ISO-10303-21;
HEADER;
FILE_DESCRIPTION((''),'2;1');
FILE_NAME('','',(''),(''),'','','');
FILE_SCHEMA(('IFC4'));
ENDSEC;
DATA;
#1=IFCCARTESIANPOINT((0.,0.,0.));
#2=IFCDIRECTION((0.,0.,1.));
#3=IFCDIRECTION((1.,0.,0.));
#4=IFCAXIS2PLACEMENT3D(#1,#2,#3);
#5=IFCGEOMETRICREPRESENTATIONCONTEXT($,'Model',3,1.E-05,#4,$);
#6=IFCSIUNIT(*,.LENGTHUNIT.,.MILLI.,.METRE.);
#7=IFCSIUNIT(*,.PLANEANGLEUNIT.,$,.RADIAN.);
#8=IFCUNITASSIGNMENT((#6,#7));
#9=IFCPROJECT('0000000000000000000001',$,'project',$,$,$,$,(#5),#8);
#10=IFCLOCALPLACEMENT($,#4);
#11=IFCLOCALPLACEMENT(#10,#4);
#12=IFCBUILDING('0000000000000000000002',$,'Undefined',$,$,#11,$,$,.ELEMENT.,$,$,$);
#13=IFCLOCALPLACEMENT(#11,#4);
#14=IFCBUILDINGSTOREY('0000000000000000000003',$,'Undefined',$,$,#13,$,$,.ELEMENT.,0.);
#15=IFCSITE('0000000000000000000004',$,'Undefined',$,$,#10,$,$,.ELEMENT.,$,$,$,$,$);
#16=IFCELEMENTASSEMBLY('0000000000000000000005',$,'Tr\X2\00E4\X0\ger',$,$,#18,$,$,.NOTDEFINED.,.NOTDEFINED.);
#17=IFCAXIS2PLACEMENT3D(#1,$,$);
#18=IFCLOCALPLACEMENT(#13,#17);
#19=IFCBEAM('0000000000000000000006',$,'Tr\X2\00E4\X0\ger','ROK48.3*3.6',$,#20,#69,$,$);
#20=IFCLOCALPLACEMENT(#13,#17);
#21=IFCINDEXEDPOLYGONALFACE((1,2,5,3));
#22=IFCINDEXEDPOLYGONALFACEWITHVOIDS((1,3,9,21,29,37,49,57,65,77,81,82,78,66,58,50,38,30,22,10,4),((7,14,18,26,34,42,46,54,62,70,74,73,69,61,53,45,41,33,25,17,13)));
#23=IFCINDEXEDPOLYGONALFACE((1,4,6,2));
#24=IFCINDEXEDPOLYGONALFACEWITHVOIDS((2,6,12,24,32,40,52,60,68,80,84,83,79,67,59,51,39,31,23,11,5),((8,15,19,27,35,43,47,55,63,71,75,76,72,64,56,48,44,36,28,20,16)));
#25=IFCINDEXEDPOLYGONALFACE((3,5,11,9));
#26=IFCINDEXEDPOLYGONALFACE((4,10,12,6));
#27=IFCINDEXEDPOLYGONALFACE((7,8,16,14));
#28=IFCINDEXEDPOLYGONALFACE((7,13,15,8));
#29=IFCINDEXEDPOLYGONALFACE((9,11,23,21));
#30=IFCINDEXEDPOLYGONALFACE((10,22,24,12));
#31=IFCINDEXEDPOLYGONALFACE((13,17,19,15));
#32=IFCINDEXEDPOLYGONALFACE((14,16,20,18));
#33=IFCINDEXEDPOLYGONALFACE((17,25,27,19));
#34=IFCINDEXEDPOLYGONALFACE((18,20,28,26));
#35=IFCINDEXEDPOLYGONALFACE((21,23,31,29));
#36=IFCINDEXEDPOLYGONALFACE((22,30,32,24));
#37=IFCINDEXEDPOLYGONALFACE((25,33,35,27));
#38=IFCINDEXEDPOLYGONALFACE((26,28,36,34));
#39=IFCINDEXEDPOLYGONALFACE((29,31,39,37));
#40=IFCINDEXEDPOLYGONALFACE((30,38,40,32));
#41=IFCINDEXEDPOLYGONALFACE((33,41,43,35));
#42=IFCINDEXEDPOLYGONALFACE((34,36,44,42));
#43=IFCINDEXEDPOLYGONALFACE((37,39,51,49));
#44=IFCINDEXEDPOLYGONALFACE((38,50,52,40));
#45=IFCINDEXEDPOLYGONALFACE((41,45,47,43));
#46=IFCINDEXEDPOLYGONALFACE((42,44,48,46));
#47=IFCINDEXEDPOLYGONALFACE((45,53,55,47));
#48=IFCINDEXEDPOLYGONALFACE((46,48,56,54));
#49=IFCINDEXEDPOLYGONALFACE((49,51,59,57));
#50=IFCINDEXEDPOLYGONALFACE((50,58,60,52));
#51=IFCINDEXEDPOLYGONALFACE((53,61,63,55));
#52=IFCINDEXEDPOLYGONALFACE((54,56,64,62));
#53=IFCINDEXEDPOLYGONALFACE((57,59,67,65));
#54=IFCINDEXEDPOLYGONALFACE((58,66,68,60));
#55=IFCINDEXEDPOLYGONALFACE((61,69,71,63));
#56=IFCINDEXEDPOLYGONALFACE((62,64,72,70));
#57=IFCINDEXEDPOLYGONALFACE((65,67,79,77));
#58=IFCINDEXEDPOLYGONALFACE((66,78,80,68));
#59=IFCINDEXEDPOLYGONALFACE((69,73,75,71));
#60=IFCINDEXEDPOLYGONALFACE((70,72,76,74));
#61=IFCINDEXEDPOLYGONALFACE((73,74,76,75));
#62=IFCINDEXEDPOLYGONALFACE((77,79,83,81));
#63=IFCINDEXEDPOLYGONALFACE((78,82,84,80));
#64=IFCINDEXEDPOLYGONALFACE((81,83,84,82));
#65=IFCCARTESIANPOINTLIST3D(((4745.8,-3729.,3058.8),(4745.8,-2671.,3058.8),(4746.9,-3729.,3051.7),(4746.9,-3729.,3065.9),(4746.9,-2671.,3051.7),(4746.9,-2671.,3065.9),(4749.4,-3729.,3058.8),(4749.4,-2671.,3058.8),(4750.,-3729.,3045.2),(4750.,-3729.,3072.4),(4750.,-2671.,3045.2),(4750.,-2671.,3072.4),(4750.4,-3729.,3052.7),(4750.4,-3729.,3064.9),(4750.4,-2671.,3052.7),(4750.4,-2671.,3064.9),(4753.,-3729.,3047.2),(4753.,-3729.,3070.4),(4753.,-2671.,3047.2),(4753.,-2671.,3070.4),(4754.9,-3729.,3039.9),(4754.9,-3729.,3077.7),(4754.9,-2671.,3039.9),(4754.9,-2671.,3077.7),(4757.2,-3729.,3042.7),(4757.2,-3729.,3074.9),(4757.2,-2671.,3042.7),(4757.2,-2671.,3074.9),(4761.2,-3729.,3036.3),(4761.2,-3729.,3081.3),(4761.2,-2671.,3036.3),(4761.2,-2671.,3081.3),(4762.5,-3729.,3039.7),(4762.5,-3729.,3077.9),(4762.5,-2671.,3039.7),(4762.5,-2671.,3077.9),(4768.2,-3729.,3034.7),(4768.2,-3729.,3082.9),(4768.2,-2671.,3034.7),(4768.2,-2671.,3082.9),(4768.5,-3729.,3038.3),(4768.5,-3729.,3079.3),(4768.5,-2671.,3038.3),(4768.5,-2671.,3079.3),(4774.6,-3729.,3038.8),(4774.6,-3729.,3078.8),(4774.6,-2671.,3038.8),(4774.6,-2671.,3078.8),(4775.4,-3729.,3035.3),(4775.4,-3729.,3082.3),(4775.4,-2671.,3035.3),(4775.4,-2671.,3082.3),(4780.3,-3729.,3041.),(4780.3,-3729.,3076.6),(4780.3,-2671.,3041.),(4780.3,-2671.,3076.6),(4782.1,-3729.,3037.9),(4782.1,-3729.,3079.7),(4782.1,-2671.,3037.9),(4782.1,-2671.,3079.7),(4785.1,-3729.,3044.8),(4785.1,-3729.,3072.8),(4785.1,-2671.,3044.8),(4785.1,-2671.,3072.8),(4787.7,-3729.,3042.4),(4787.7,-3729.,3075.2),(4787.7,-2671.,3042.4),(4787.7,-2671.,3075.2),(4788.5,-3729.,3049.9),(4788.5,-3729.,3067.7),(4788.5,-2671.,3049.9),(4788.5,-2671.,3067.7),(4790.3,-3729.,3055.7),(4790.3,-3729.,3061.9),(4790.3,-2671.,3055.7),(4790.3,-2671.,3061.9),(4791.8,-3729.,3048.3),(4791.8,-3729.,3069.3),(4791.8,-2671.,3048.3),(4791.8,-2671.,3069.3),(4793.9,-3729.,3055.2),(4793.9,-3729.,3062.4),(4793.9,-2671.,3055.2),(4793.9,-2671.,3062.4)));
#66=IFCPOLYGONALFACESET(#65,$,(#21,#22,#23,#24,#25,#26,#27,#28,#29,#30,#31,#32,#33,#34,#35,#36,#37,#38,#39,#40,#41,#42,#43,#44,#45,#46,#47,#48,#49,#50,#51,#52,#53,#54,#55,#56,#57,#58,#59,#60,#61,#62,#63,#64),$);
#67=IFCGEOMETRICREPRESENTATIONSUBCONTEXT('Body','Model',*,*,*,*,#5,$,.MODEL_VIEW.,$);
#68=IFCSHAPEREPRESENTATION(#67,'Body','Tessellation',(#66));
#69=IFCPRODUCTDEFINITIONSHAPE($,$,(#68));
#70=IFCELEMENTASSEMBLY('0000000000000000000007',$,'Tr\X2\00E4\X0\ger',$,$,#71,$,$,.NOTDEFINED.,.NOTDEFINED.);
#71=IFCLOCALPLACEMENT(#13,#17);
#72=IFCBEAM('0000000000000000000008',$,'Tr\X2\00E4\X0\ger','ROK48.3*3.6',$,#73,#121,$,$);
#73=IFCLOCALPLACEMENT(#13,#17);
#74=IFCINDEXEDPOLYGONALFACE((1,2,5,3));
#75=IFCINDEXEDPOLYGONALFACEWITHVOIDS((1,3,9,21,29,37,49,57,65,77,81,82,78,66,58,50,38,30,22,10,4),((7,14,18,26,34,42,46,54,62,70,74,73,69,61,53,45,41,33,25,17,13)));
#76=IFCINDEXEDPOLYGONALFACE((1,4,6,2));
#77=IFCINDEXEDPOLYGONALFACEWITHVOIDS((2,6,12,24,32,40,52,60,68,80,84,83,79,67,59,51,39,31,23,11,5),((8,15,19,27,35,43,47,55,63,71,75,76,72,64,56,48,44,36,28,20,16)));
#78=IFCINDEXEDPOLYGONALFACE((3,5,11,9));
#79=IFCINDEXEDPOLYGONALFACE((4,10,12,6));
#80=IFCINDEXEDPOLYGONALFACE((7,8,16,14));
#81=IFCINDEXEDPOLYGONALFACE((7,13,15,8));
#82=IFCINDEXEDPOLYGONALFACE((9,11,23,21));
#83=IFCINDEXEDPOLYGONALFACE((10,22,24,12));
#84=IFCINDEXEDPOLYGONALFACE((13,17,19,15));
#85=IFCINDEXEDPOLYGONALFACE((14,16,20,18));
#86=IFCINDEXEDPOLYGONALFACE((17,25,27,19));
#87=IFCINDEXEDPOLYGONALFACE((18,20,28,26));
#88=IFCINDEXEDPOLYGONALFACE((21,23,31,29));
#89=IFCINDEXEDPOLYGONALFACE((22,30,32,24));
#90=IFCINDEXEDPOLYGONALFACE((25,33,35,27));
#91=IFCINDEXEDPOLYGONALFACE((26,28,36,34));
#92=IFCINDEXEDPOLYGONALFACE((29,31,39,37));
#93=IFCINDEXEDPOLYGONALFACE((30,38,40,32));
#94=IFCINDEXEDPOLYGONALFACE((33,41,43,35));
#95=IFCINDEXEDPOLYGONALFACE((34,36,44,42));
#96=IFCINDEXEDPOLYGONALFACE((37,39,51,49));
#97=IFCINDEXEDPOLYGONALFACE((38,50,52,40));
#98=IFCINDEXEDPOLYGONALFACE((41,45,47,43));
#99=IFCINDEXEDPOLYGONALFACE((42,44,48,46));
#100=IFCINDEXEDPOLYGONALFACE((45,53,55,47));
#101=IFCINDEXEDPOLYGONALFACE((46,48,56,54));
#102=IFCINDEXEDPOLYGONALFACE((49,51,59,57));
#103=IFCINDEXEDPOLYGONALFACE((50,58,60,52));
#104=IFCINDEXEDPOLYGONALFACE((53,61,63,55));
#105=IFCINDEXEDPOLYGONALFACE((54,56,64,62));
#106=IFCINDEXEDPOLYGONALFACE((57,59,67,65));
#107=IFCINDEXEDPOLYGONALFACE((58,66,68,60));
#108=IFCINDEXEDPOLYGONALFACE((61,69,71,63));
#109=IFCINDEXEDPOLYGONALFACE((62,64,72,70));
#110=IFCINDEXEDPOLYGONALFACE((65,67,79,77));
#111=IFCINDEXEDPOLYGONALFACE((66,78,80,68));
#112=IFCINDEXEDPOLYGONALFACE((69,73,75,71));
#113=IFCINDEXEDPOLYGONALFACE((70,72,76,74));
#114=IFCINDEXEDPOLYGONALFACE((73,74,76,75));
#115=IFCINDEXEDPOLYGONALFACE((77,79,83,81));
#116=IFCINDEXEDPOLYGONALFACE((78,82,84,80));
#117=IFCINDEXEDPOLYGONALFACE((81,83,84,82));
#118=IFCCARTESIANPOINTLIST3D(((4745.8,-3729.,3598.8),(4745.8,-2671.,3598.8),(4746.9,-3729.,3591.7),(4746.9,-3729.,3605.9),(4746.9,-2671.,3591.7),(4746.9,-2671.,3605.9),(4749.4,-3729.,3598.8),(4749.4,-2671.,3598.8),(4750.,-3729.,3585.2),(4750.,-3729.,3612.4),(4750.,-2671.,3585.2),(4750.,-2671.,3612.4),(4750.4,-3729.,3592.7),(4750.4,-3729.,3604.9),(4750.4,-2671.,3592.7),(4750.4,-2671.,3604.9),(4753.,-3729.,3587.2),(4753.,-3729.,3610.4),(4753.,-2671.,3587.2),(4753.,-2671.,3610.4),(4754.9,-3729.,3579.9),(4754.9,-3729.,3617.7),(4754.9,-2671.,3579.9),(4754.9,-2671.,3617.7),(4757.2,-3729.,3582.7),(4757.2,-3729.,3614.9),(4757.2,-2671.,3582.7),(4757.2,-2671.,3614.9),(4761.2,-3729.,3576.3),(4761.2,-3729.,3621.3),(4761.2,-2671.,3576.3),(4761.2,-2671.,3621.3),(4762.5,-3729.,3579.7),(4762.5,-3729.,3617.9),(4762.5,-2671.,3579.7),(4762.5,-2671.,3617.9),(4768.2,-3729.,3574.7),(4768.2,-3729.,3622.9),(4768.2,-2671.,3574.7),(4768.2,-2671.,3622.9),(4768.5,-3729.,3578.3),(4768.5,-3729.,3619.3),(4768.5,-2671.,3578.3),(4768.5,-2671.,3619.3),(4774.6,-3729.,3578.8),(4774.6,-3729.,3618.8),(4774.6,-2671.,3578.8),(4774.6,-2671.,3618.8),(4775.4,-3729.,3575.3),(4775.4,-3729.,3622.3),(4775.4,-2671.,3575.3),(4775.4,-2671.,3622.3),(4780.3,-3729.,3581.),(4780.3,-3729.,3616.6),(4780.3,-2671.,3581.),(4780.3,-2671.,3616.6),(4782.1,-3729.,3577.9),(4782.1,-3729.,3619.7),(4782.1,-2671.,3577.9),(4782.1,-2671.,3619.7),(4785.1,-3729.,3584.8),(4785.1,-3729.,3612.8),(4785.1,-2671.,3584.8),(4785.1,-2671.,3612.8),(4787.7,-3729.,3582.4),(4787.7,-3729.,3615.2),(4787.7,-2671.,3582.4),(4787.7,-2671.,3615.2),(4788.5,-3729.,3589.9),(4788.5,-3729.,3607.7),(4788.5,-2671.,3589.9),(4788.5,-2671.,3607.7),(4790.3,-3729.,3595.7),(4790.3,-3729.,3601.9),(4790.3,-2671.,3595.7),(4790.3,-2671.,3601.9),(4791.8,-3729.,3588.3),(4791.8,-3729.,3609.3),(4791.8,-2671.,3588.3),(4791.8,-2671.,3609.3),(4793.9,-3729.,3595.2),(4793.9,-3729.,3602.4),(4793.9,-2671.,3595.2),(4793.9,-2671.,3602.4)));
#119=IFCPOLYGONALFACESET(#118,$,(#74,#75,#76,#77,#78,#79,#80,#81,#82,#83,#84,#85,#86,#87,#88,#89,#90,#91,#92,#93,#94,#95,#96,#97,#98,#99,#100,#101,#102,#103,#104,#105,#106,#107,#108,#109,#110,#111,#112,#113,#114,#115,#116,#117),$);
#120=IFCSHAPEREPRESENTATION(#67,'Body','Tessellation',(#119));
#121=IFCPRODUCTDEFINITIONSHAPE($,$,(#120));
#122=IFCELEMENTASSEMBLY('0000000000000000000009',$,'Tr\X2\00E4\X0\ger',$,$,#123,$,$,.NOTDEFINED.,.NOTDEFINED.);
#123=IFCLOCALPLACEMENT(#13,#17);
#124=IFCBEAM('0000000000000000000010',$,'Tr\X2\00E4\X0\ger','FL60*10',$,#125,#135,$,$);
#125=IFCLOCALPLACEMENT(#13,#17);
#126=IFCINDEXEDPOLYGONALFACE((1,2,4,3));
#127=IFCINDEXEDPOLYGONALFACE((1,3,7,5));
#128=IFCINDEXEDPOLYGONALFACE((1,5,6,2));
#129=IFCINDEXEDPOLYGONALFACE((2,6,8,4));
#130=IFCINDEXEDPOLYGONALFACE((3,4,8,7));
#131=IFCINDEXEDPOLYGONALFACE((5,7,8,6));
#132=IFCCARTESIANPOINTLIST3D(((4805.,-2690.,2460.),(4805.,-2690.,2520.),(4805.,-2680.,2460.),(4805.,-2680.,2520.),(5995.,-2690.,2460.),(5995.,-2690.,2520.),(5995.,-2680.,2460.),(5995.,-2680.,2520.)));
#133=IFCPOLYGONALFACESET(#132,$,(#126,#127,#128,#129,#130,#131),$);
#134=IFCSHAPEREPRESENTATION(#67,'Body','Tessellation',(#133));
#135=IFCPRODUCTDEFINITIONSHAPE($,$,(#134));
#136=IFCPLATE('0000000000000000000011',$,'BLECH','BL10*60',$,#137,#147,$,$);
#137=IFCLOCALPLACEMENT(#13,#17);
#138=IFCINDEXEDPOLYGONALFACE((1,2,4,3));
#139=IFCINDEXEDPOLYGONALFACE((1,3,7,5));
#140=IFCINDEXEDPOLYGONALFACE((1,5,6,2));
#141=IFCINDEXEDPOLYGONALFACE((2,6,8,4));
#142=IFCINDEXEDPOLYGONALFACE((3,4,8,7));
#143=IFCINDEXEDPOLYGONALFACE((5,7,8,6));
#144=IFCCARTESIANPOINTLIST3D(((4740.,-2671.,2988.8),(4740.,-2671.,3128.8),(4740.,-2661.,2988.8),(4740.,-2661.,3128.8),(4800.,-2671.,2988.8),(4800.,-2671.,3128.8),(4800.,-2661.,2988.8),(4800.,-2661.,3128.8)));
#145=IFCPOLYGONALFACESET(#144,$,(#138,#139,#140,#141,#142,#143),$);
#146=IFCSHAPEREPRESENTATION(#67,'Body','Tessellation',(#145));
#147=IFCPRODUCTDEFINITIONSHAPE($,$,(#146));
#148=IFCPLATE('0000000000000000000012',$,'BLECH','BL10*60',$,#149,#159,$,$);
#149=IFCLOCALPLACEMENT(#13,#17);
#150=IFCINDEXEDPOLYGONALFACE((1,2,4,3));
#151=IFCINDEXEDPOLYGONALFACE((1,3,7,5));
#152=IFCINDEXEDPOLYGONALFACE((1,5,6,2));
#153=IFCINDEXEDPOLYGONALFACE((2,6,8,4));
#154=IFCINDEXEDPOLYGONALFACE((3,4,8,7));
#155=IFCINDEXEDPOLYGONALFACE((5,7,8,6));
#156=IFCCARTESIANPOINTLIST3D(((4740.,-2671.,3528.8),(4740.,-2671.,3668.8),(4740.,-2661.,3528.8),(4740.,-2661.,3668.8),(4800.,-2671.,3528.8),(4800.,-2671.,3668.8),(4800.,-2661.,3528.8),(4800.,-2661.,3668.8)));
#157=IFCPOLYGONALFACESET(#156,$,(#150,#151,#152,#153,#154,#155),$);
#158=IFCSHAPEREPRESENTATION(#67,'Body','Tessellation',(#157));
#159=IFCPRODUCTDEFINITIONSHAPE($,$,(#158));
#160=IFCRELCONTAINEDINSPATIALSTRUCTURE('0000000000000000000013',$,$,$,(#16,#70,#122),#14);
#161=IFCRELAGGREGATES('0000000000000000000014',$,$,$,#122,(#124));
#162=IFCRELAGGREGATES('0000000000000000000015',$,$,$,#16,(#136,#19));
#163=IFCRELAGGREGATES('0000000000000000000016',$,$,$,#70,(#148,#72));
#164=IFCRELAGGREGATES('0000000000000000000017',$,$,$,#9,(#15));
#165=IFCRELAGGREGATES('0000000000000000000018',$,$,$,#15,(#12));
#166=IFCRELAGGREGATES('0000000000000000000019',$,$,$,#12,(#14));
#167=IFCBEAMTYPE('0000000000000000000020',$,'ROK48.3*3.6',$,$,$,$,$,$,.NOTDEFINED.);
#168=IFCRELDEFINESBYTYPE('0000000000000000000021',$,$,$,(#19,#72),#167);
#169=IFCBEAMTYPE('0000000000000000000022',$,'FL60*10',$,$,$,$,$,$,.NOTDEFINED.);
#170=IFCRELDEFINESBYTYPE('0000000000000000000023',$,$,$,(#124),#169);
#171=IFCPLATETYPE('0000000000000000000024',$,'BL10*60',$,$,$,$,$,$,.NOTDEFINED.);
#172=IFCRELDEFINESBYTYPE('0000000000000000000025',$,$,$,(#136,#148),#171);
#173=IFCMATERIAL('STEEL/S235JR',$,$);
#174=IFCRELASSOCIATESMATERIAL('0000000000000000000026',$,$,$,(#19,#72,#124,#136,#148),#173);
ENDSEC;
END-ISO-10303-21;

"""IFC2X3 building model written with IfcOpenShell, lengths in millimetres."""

from ifc_helpers import new_model, si_unit, frame, origin_with_axes, origin_2d_with_axis, place, context, subcontext, project, spatial, polyline, rectangle, hollow_circle, outline, extrude, material, type_object, element, aggregate, save


model = new_model("IFC2X3")

# Units and contexts
model_context = context("Model", 3, precision=1e-05, world=origin_with_axes())
body_context = subcontext(model_context, "Body", "Model", "MODEL_VIEW")
ifc_project = project(units=[si_unit("LENGTHUNIT", "METRE", prefix="MILLI"), si_unit("PLANEANGLEUNIT", "RADIAN")], contexts=[model_context])

# Site, building, storey
site_placement = place(None, origin_with_axes())
site = spatial("IfcSite", under=ifc_project, at=site_placement, Name="Undefined", CompositionType="ELEMENT")
building_placement = place(site_placement, origin_with_axes())
building = spatial("IfcBuilding", under=site, at=building_placement, Name="Undefined", CompositionType="ELEMENT")
storey_placement = place(building_placement, origin_with_axes())
storey = spatial("IfcBuildingStorey", under=building, at=storey_placement, Name="Undefined", CompositionType="ELEMENT", Elevation=0.0)

# Element assemblies, beams
assembly_1_placement = place(storey_placement, origin_with_axes())
assembly_1 = element("IfcElementAssembly", 1, at=assembly_1_placement, inside=storey, Name="Träger", AssemblyPlace="NOTDEFINED", PredefinedType="NOTDEFINED")
ifc_material_1 = material(Name="STEEL/S235JR")
beam_type_1 = type_object("IfcBeamType", Name="ROK48.3*3.6", PredefinedType="NOTDEFINED")
beam_1_placement = place(assembly_1_placement, frame((4770.0, -2671.0, 3058.8), z_axis=(0.0, 0.0, 1.0), x_axis=(0.0, -1.0, 0.0)))
beam_1 = element("IfcBeam", 2, at=beam_1_placement, type_object=beam_type_1, material=ifc_material_1, Name="Träger", Description="ROK48.3*3.6", context=body_context, shape_type="SweptSolid", body=[
    extrude(hollow_circle(Radius=24.1, WallThickness=3.6, at=origin_2d_with_axis()), frame((1058.0, 0.0, 0.0), z_axis=(-1.0, 0.0, 0.0), x_axis=(0.0, -1.0, 0.0)), (0.0, 0.0, 1.0), 1058.0),
])
assembly_2_placement = place(storey_placement, origin_with_axes())
assembly_2 = element("IfcElementAssembly", 3, at=assembly_2_placement, inside=storey, Name="Träger", AssemblyPlace="NOTDEFINED", PredefinedType="NOTDEFINED")
beam_2_placement = place(assembly_2_placement, frame((4770.0, -2671.0, 3598.8), z_axis=(0.0, 0.0, 1.0), x_axis=(0.0, -1.0, 0.0)))
beam_2 = element("IfcBeam", 4, at=beam_2_placement, type_object=beam_type_1, material=ifc_material_1, Name="Träger", Description="ROK48.3*3.6", context=body_context, shape_type="SweptSolid", body=[
    extrude(hollow_circle(Radius=24.1, WallThickness=3.6, at=origin_2d_with_axis()), frame((1058.0, 0.0, 0.0), z_axis=(-1.0, 0.0, 0.0), x_axis=(0.0, -1.0, 0.0)), (0.0, 0.0, 1.0), 1058.0),
])
assembly_3_placement = place(storey_placement, origin_with_axes())
assembly_3 = element("IfcElementAssembly", 5, at=assembly_3_placement, inside=storey, Name="Träger", AssemblyPlace="NOTDEFINED", PredefinedType="NOTDEFINED")
beam_type_2 = type_object("IfcBeamType", Name="FL60*10", PredefinedType="NOTDEFINED")
beam_3_placement = place(assembly_3_placement, frame((4805.0, -2685.0, 2490.0), z_axis=(0.0, 0.0, 1.0), x_axis=(1.0, 0.0, 0.0)))
beam_3 = element("IfcBeam", 6, at=beam_3_placement, type_object=beam_type_2, material=ifc_material_1, Name="Träger", Description="FL60*10", context=body_context, shape_type="SweptSolid", body=[
    extrude(rectangle(XDim=10.0, YDim=60.0, at=origin_2d_with_axis()), frame((1190.0, 0.0, 0.0), z_axis=(-1.0, 0.0, 0.0), x_axis=(0.0, -1.0, 0.0)), (0.0, 0.0, 1.0), 1190.0),
])
aggregate(assembly_3, [beam_3])

# Plates
plate_type_1 = type_object("IfcPlateType", Name="BL10*60", PredefinedType="NOTDEFINED")
plate_1_placement = place(assembly_1_placement, frame((4740.0, -2666.0, 3128.8), z_axis=(0.0, 1.0, 0.0), x_axis=(1.0, 0.0, 0.0)))
plate_1 = element("IfcPlate", 7, at=plate_1_placement, type_object=plate_type_1, material=ifc_material_1, Name="BLECH", Description="BL10*60", context=body_context, shape_type="SweptSolid", body=[
    extrude(outline(polyline([(0.0, 0.0), (60.0, 0.0), (60.0, 140.0), (0.0, 140.0), (0.0, 0.0)])), frame((0.0, 0.0, -5.0), z_axis=(0.0, 0.0, 1.0), x_axis=(1.0, 0.0, 0.0)), (0.0, 0.0, 1.0), 10.0),
])
aggregate(assembly_1, [plate_1, beam_1])
plate_2_placement = place(assembly_2_placement, frame((4740.0, -2666.0, 3668.8), z_axis=(0.0, 1.0, 0.0), x_axis=(1.0, 0.0, 0.0)))
plate_2 = element("IfcPlate", 8, at=plate_2_placement, type_object=plate_type_1, material=ifc_material_1, Name="BLECH", Description="BL10*60", context=body_context, shape_type="SweptSolid", body=[
    extrude(outline(polyline([(0.0, 0.0), (60.0, 0.0), (60.0, 140.0), (0.0, 140.0), (0.0, 0.0)])), frame((0.0, 0.0, -5.0), z_axis=(0.0, 0.0, 1.0), x_axis=(1.0, 0.0, 0.0)), (0.0, 0.0, 1.0), 10.0),
])
aggregate(assembly_2, [plate_2, beam_2])

save(model, "model.ifc")
